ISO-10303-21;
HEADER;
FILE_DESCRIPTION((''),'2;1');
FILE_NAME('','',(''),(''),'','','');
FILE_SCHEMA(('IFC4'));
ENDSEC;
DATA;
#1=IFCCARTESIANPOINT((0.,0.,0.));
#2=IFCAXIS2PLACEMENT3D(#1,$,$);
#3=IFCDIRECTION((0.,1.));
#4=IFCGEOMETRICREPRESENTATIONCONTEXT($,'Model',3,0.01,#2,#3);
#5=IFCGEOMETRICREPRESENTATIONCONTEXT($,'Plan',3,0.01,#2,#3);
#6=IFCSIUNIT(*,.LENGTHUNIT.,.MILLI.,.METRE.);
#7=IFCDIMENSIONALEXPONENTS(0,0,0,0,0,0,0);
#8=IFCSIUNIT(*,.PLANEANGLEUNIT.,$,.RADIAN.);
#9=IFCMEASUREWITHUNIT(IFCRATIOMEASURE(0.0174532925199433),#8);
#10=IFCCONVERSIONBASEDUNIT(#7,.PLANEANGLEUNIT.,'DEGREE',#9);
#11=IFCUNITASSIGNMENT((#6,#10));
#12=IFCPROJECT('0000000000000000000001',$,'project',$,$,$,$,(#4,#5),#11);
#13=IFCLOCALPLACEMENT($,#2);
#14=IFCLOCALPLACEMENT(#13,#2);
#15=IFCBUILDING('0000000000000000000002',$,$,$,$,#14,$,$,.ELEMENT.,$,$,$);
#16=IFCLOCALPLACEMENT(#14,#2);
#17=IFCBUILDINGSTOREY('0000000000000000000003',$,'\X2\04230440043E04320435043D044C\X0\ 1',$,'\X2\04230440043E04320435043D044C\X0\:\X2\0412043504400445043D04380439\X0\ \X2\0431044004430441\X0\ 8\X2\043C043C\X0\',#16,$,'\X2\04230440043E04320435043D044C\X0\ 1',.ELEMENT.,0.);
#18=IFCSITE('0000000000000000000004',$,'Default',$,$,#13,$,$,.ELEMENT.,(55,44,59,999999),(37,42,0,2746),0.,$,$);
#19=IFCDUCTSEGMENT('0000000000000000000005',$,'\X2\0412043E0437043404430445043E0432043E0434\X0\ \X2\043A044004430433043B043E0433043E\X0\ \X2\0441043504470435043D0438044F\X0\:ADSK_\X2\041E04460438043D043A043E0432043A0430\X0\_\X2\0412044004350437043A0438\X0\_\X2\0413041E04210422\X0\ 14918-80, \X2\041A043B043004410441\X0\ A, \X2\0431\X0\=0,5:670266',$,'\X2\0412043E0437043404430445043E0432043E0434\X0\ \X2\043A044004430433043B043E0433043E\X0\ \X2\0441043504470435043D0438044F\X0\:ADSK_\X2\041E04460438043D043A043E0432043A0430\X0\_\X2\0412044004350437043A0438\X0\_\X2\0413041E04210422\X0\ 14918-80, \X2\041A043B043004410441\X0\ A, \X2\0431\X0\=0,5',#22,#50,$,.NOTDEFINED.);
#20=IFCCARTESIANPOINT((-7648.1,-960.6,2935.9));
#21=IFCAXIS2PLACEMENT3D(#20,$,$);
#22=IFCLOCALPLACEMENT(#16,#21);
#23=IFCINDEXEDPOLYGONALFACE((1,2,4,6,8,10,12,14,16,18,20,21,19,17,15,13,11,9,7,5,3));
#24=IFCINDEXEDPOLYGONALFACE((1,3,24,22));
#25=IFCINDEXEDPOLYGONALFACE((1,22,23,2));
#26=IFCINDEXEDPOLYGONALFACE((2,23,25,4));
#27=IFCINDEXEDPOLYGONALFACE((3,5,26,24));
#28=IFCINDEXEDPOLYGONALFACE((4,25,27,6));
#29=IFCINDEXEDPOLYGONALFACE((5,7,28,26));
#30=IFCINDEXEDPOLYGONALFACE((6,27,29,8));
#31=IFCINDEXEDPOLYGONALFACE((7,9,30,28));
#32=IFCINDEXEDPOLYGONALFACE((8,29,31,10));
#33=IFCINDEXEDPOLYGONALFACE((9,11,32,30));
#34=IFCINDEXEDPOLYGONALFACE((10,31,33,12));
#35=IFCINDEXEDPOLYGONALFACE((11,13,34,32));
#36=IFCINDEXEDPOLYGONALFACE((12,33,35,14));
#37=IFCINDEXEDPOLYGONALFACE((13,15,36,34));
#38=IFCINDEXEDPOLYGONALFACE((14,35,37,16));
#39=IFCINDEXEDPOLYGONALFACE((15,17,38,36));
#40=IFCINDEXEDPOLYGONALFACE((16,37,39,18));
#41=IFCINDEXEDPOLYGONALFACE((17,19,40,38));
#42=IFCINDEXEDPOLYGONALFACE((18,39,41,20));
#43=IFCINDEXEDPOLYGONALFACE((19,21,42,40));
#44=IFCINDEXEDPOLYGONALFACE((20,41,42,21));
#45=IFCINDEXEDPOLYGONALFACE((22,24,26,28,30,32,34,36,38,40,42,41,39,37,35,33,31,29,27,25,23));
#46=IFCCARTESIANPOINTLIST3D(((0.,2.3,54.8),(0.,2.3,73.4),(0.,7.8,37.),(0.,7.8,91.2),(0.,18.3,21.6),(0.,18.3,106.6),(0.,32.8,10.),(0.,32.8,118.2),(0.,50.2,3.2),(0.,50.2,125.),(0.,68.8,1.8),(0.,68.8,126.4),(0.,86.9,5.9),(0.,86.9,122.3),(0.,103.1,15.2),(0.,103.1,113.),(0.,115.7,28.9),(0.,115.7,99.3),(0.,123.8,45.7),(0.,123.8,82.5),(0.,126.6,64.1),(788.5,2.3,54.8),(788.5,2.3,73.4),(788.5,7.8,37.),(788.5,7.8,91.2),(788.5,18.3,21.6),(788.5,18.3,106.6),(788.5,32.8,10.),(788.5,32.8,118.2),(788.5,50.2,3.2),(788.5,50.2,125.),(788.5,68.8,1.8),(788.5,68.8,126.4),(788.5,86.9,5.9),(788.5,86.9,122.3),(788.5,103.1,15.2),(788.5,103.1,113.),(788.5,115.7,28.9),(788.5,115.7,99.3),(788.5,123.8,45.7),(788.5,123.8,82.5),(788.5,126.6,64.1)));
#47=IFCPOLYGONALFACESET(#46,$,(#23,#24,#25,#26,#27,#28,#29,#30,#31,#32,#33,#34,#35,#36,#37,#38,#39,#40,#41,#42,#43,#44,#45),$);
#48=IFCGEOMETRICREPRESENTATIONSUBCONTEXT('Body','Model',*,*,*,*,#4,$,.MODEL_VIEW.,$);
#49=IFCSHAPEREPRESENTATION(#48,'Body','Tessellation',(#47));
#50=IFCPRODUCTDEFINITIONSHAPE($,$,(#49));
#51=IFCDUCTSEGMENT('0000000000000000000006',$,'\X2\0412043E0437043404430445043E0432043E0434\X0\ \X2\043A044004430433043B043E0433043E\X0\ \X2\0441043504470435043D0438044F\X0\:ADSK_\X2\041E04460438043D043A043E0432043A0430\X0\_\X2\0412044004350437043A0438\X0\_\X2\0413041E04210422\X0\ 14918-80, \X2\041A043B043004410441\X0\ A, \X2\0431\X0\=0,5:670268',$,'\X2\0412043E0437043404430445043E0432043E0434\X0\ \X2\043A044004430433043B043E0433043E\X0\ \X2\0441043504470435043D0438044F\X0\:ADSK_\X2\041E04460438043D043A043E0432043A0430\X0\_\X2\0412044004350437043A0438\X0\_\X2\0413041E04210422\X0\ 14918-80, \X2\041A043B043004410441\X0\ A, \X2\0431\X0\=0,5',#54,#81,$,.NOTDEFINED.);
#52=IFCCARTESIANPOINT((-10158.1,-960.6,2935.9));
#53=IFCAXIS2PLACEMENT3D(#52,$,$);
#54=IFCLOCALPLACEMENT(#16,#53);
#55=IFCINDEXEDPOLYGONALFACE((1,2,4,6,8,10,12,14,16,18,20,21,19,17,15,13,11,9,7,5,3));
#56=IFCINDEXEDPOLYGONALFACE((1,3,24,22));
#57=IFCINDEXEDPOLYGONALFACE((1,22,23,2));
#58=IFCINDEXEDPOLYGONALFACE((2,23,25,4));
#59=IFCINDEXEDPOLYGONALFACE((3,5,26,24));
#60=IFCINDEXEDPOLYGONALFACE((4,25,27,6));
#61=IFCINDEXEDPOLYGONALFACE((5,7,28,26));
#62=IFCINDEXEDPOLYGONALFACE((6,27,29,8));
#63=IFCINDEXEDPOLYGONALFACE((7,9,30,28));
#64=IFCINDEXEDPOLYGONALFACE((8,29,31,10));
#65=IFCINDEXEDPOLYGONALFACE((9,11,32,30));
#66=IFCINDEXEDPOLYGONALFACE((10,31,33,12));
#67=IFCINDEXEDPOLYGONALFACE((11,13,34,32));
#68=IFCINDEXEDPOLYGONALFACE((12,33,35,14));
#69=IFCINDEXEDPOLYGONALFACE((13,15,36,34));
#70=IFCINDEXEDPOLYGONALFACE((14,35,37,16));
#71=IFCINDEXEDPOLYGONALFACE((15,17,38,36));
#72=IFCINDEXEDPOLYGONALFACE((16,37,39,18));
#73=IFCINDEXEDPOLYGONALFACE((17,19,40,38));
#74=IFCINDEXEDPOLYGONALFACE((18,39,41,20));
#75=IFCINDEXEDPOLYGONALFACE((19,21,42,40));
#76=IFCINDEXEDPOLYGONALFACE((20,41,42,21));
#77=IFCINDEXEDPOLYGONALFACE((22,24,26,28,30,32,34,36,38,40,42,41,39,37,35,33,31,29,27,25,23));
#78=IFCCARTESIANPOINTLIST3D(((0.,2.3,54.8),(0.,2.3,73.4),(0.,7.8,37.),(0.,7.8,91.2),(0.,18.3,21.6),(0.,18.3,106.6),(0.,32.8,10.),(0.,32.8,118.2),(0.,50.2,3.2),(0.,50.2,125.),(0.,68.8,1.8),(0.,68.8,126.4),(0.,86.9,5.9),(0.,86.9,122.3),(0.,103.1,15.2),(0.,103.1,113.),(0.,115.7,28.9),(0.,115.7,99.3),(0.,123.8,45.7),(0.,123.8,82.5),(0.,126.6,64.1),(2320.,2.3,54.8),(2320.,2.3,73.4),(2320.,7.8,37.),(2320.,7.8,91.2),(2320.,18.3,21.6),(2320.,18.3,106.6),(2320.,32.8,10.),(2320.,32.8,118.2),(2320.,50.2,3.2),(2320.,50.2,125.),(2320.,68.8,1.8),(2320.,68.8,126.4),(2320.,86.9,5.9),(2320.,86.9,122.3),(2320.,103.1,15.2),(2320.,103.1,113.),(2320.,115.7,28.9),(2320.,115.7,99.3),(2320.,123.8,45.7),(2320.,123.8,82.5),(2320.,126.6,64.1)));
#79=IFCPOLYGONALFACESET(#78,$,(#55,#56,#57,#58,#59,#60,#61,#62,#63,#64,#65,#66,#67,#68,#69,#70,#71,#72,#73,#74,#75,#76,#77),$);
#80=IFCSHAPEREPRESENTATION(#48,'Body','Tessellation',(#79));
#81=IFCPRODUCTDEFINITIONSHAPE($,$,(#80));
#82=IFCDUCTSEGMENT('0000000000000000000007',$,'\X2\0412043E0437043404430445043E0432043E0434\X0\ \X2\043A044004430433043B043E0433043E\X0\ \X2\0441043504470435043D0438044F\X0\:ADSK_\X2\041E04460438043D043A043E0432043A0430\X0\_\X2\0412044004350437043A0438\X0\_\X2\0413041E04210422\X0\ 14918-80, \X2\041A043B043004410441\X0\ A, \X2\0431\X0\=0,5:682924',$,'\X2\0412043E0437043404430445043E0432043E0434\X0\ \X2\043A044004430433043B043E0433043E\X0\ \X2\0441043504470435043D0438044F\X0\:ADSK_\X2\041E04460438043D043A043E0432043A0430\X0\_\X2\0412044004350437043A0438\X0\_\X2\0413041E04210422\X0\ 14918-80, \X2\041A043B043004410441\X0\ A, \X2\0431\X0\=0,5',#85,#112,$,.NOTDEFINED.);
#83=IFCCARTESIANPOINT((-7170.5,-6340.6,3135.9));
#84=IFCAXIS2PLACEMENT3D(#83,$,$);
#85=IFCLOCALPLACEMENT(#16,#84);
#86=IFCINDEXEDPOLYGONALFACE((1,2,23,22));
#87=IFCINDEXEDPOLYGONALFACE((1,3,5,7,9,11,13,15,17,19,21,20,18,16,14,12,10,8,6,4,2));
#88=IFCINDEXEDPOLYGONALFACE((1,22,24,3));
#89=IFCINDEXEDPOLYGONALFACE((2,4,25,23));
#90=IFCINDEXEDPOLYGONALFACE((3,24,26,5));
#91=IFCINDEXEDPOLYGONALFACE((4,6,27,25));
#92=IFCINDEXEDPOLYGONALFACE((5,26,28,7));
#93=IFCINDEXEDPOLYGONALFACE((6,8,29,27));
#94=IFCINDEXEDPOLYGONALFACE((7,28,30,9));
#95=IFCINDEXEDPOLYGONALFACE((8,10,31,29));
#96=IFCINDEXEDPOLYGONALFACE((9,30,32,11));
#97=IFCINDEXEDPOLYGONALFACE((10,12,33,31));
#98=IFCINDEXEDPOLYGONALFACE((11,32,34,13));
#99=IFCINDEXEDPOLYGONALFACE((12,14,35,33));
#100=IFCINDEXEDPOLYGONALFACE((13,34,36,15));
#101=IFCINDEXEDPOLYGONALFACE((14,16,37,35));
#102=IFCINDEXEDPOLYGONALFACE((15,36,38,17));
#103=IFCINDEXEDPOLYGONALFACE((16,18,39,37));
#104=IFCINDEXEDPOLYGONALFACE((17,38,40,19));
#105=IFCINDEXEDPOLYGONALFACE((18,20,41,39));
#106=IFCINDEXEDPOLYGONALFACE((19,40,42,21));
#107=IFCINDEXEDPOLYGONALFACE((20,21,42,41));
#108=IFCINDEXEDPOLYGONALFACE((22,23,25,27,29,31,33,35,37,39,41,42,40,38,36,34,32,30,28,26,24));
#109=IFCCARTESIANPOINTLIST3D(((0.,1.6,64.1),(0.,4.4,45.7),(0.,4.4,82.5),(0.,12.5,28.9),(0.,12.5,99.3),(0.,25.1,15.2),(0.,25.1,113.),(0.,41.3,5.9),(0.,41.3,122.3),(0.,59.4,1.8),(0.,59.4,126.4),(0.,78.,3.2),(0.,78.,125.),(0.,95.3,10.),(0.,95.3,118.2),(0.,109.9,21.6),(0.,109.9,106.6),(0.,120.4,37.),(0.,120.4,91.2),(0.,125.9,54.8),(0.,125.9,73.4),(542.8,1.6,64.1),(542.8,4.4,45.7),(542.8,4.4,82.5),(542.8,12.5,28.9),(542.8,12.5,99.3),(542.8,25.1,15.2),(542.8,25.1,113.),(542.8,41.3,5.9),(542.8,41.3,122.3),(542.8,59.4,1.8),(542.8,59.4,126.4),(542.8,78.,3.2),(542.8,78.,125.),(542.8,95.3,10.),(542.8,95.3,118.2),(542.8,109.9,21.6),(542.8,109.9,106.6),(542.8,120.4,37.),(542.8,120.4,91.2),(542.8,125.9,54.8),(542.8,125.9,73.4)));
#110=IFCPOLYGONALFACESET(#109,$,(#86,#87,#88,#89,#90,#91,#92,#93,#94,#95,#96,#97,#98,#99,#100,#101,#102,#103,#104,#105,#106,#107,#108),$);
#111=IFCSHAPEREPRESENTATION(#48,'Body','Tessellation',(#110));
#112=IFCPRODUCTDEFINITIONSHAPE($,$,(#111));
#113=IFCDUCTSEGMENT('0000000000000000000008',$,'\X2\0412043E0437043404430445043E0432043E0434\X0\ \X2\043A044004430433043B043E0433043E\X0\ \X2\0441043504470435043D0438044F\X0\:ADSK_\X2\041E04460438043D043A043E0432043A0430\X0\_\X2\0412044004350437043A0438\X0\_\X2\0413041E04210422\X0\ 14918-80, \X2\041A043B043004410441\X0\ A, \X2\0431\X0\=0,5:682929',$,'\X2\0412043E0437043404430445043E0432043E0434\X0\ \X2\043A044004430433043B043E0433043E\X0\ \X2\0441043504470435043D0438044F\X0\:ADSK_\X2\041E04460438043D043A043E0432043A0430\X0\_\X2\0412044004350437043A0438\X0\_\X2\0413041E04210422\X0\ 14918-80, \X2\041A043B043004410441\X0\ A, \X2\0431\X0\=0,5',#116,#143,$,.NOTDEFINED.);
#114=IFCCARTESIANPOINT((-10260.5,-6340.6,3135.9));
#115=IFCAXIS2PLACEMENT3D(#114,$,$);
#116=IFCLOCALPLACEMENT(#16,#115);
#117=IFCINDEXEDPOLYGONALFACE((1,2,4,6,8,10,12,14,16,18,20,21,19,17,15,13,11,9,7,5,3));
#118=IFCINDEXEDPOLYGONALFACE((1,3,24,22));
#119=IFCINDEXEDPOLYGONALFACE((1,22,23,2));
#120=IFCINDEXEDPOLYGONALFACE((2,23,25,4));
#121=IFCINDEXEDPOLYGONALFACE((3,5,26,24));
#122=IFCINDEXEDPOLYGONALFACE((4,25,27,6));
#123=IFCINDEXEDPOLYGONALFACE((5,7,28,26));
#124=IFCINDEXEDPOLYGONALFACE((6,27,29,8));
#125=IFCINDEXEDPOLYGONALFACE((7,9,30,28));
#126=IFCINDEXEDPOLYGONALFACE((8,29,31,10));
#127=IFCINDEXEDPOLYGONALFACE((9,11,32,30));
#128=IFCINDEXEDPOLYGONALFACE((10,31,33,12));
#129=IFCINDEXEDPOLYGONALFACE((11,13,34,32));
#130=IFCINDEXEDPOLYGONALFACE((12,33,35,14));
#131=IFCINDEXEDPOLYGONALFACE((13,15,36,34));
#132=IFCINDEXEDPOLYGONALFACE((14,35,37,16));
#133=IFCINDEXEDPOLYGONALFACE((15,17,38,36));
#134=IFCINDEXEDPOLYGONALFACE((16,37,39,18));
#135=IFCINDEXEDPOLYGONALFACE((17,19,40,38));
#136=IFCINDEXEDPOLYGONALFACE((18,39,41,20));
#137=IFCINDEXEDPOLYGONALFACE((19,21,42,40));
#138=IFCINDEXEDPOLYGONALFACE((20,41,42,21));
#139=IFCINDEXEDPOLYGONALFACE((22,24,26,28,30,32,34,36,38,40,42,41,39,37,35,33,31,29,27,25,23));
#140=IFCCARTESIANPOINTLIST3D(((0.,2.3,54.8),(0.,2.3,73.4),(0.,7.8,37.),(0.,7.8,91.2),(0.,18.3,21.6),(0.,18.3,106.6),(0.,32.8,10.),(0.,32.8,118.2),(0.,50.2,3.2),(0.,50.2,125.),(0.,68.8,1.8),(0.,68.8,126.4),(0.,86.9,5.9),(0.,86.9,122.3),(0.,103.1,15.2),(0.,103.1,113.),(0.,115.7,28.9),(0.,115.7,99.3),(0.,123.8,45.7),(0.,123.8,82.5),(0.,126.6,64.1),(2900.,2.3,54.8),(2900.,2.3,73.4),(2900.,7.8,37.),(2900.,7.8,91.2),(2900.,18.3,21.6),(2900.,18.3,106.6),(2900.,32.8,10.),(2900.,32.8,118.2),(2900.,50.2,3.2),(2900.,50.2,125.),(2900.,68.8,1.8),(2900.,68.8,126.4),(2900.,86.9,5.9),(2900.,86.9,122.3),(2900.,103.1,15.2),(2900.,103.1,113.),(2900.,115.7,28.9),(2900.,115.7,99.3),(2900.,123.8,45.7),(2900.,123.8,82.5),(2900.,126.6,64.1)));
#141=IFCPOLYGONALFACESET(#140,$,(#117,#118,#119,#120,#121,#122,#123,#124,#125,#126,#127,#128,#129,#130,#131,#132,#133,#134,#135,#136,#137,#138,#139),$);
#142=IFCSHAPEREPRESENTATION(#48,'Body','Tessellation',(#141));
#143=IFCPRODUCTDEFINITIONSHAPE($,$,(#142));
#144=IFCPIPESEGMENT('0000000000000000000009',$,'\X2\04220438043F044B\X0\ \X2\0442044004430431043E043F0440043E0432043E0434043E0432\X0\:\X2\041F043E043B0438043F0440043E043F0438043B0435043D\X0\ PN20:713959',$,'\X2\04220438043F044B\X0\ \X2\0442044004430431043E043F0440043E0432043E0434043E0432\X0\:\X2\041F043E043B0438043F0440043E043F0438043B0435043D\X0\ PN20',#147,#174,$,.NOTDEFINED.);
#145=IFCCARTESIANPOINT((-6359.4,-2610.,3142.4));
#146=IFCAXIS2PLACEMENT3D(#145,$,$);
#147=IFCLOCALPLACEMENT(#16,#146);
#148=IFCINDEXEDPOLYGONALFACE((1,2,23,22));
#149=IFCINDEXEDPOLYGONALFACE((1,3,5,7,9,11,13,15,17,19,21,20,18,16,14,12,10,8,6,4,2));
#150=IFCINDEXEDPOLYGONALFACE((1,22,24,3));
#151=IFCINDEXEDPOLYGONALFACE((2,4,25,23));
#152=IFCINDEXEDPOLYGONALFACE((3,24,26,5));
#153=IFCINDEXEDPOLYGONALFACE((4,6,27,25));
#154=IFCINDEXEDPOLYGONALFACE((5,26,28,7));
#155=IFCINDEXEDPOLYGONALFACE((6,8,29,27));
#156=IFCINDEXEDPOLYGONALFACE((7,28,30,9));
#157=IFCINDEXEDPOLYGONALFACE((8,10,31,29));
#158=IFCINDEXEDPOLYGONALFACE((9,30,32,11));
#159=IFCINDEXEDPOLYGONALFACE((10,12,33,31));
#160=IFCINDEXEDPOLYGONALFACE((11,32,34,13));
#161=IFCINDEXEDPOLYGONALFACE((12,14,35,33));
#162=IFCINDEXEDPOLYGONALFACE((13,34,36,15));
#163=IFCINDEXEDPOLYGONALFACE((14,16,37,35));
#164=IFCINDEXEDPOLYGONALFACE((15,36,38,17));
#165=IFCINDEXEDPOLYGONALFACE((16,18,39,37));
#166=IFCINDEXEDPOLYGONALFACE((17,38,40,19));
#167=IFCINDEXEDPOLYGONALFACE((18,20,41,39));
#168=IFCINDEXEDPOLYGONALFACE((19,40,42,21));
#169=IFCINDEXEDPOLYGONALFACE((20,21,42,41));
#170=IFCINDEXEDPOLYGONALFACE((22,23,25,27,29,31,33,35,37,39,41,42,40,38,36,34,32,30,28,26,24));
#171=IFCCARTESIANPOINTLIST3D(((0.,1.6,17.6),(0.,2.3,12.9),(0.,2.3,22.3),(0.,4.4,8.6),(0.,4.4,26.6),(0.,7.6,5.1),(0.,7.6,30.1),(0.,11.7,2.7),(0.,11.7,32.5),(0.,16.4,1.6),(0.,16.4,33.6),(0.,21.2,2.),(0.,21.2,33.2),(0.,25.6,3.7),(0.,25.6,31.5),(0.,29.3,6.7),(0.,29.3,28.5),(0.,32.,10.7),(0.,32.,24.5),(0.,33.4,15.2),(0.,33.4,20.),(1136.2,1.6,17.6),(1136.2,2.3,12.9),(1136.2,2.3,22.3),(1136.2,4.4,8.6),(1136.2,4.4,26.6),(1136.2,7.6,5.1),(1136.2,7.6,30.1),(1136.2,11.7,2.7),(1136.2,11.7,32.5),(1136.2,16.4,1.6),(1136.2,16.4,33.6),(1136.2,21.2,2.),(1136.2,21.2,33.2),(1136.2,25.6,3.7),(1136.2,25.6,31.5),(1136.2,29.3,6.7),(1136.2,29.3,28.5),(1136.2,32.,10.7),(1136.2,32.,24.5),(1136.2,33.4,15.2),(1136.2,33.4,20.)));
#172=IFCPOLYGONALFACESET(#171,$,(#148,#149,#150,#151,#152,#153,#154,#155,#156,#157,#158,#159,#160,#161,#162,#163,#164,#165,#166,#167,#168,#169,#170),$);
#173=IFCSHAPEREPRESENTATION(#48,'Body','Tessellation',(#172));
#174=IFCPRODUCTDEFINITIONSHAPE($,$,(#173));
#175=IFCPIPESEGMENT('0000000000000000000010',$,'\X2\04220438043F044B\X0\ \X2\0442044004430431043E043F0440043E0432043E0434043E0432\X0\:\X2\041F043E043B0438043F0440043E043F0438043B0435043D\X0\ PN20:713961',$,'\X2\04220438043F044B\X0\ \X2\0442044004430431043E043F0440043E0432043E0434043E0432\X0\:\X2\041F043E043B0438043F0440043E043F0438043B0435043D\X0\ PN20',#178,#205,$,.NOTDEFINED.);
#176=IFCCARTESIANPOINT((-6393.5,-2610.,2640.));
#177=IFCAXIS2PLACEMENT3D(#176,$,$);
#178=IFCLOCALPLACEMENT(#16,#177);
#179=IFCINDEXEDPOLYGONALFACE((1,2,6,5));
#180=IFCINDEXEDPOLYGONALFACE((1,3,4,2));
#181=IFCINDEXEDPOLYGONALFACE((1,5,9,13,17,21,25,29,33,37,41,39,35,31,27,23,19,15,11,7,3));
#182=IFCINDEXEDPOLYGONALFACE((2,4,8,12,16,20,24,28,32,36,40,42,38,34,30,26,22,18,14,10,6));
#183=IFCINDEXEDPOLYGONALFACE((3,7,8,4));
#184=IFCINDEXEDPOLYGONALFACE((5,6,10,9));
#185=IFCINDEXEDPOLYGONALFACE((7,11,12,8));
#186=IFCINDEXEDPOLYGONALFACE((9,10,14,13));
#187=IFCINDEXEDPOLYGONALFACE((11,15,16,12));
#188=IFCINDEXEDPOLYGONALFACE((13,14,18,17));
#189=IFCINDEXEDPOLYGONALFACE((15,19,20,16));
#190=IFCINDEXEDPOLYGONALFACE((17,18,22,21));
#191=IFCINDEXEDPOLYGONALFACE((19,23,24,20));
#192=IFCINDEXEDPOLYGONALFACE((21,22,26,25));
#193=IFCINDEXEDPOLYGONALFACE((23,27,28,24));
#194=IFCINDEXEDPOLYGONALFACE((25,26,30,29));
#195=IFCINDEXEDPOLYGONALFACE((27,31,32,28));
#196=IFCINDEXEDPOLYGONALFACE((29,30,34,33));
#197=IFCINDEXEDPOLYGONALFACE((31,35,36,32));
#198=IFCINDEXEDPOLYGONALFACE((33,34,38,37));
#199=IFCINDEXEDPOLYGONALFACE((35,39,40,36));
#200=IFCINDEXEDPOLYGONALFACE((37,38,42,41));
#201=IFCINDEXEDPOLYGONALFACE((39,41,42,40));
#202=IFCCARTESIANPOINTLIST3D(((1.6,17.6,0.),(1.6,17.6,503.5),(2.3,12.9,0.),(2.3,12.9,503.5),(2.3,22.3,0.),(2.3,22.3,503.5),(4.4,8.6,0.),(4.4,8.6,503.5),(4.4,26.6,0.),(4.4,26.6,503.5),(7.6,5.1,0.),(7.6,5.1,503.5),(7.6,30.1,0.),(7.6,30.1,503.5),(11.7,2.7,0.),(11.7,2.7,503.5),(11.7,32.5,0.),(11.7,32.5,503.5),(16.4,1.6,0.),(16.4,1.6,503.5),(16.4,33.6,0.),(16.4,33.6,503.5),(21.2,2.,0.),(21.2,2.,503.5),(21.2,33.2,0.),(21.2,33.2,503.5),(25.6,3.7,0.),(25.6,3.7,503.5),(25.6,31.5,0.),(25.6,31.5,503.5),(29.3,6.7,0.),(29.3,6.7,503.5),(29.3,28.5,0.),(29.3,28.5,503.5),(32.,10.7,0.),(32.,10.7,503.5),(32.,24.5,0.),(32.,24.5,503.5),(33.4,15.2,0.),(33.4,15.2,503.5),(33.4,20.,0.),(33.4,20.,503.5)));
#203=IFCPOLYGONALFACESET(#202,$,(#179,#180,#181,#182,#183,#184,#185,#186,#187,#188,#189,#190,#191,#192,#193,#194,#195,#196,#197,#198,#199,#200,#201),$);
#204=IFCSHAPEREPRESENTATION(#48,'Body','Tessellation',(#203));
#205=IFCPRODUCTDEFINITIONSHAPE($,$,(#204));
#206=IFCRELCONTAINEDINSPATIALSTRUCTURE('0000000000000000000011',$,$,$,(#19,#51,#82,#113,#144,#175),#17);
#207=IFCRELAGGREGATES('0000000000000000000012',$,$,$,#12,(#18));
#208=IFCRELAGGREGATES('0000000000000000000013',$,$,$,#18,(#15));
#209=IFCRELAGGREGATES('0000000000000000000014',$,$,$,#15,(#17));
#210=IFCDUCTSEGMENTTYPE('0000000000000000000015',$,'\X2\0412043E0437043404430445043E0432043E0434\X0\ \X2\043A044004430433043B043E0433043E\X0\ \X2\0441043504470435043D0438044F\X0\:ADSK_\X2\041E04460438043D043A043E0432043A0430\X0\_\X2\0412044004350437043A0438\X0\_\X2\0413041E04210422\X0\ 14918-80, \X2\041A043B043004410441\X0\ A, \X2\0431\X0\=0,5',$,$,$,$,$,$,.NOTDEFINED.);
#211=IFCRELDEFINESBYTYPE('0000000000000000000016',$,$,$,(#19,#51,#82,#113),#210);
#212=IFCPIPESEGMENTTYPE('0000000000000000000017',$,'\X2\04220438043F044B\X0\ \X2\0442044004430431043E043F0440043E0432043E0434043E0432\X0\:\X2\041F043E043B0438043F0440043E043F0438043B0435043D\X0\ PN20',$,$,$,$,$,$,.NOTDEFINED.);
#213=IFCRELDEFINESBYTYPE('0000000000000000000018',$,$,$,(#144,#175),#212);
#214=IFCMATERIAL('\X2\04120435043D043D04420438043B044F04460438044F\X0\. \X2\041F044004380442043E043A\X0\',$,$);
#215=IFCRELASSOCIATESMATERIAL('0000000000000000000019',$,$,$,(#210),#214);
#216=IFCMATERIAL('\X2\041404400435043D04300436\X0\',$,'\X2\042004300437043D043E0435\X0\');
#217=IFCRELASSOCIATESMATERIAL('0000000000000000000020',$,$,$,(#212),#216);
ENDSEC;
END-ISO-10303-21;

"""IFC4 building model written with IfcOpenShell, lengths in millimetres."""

from ifc_helpers import new_model, entity, si_unit, converted_unit, direction, frame, frame_2d, origin, origin_2d_with_axis, place, context, subcontext, project, spatial, circle, extrude, material, type_object, element, save


model = new_model("IFC4")

# Units and contexts
model_context = context("Model", 3, precision=0.01, world=origin(), true_north=direction((0.0, 1.0)))
plan_context = context("Plan", 3, precision=0.01, world=origin(), true_north=direction((0.0, 1.0)))
body_context = subcontext(model_context, "Body", "Model", "MODEL_VIEW")
ifc_project = project(units=[si_unit("LENGTHUNIT", "METRE", prefix="MILLI"), converted_unit("PLANEANGLEUNIT", "DEGREE", entity("IfcRatioMeasure", 0.0174532925199433), si_unit("PLANEANGLEUNIT", "RADIAN"), dimensions=[0, 0, 0, 0, 0, 0, 0])], contexts=[model_context, plan_context])

# Site, building, storey
site_placement = place(None, origin())
site = spatial("IfcSite", under=ifc_project, at=site_placement, Name="Default", CompositionType="ELEMENT", RefLatitude=(55, 44, 59, 999999), RefLongitude=(37, 42, 0, 2746), RefElevation=0.0)
building_placement = place(site_placement, origin())
building = spatial("IfcBuilding", under=site, at=building_placement, CompositionType="ELEMENT")
storey_placement = place(building_placement, origin())
storey = spatial("IfcBuildingStorey", under=building, at=storey_placement, Name="Уровень 1", ObjectType="Уровень:Верхний брус 8мм", LongName="Уровень 1", CompositionType="ELEMENT", Elevation=0.0)

# Duct segments
ifc_material_1 = material(Name="Веннтиляция. Приток")
duct_segment_type = type_object("IfcDuctSegmentType", Name="Воздуховод круглого сечения:ADSK_Оцинковка_Врезки_ГОСТ 14918-80, Класс A, б=0,5", PredefinedType="NOTDEFINED", material=ifc_material_1)
duct_segment_1_placement = place(storey_placement, frame((-7648.1, -960.6, 2935.9)))
element("IfcDuctSegment", 1, at=duct_segment_1_placement, inside=storey, type_object=duct_segment_type, Name="Воздуховод круглого сечения:ADSK_Оцинковка_Врезки_ГОСТ 14918-80, Класс A, б=0,5:670266", ObjectType="Воздуховод круглого сечения:ADSK_Оцинковка_Врезки_ГОСТ 14918-80, Класс A, б=0,5", PredefinedType="NOTDEFINED", context=body_context, shape_type="SweptSolid", body=[
    extrude(circle(Radius=62.5, at=frame_2d((0.0, 0.0), x_axis=(1.0, 0.0))), frame((0.0, 64.1, 64.1), z_axis=(1.0, 0.0, 0.0), x_axis=(0.0, 1.0, 0.0)), (0.0, 0.0, 1.0), 788.5),
])
duct_segment_2_placement = place(storey_placement, frame((-10158.1, -960.6, 2935.9)))
element("IfcDuctSegment", 2, at=duct_segment_2_placement, inside=storey, type_object=duct_segment_type, Name="Воздуховод круглого сечения:ADSK_Оцинковка_Врезки_ГОСТ 14918-80, Класс A, б=0,5:670268", ObjectType="Воздуховод круглого сечения:ADSK_Оцинковка_Врезки_ГОСТ 14918-80, Класс A, б=0,5", PredefinedType="NOTDEFINED", context=body_context, shape_type="SweptSolid", body=[
    extrude(circle(Radius=62.5, at=frame_2d((0.0, 0.0), x_axis=(1.0, 0.0))), frame((0.0, 64.1, 64.1), z_axis=(1.0, 0.0, 0.0), x_axis=(0.0, 1.0, 0.0)), (0.0, 0.0, 1.0), 2320.0),
])
duct_segment_3_placement = place(storey_placement, frame((-7170.5, -6340.6, 3135.9)))
element("IfcDuctSegment", 3, at=duct_segment_3_placement, inside=storey, type_object=duct_segment_type, Name="Воздуховод круглого сечения:ADSK_Оцинковка_Врезки_ГОСТ 14918-80, Класс A, б=0,5:682924", ObjectType="Воздуховод круглого сечения:ADSK_Оцинковка_Врезки_ГОСТ 14918-80, Класс A, б=0,5", PredefinedType="NOTDEFINED", context=body_context, shape_type="SweptSolid", body=[
    extrude(circle(Radius=62.5, at=origin_2d_with_axis()), frame((0.0, 64.1, 64.1), z_axis=(1.0, 0.0, 0.0), x_axis=(0.0, -1.0, 0.0)), (0.0, 0.0, 1.0), 542.8),
])
duct_segment_4_placement = place(storey_placement, frame((-10260.5, -6340.6, 3135.9)))
element("IfcDuctSegment", 4, at=duct_segment_4_placement, inside=storey, type_object=duct_segment_type, Name="Воздуховод круглого сечения:ADSK_Оцинковка_Врезки_ГОСТ 14918-80, Класс A, б=0,5:682929", ObjectType="Воздуховод круглого сечения:ADSK_Оцинковка_Врезки_ГОСТ 14918-80, Класс A, б=0,5", PredefinedType="NOTDEFINED", context=body_context, shape_type="SweptSolid", body=[
    extrude(circle(Radius=62.5, at=origin_2d_with_axis()), frame((0.0, 64.1, 64.1), z_axis=(1.0, 0.0, 0.0), x_axis=(0.0, 1.0, 0.0)), (0.0, 0.0, 1.0), 2900.0),
])

# Pipe segments
ifc_material_2 = material(Name="Дренаж", Category="Разное")
pipe_segment_type_1 = type_object("IfcPipeSegmentType", Name="Типы трубопроводов:Полипропилен PN20", PredefinedType="NOTDEFINED", material=ifc_material_2)
pipe_segment_1_placement = place(storey_placement, frame((-6359.4, -2610.0, 3142.4)))
element("IfcPipeSegment", 5, at=pipe_segment_1_placement, inside=storey, type_object=pipe_segment_type_1, Name="Типы трубопроводов:Полипропилен PN20:713959", ObjectType="Типы трубопроводов:Полипропилен PN20", PredefinedType="NOTDEFINED", context=body_context, shape_type="SweptSolid", body=[
    extrude(circle(Radius=16.0, at=origin_2d_with_axis()), frame((0.0, 17.6, 17.6), z_axis=(1.0, 0.0, 0.0), x_axis=(0.0, -1.0, 0.0)), (0.0, 0.0, 1.0), 1136.2),
])
pipe_segment_2_placement = place(storey_placement, frame((-6393.5, -2610.0, 2640.0)))
element("IfcPipeSegment", 6, at=pipe_segment_2_placement, inside=storey, type_object=pipe_segment_type_1, Name="Типы трубопроводов:Полипропилен PN20:713961", ObjectType="Типы трубопроводов:Полипропилен PN20", PredefinedType="NOTDEFINED", context=body_context, shape_type="SweptSolid", body=[
    extrude(circle(Radius=16.0, at=origin_2d_with_axis()), frame((17.6, 17.6, 0.0), z_axis=(0.0, 0.0, 1.0), x_axis=(-1.0, 0.0, 0.0)), (0.0, 0.0, 1.0), 503.5),
])

save(model, "model.ifc")
